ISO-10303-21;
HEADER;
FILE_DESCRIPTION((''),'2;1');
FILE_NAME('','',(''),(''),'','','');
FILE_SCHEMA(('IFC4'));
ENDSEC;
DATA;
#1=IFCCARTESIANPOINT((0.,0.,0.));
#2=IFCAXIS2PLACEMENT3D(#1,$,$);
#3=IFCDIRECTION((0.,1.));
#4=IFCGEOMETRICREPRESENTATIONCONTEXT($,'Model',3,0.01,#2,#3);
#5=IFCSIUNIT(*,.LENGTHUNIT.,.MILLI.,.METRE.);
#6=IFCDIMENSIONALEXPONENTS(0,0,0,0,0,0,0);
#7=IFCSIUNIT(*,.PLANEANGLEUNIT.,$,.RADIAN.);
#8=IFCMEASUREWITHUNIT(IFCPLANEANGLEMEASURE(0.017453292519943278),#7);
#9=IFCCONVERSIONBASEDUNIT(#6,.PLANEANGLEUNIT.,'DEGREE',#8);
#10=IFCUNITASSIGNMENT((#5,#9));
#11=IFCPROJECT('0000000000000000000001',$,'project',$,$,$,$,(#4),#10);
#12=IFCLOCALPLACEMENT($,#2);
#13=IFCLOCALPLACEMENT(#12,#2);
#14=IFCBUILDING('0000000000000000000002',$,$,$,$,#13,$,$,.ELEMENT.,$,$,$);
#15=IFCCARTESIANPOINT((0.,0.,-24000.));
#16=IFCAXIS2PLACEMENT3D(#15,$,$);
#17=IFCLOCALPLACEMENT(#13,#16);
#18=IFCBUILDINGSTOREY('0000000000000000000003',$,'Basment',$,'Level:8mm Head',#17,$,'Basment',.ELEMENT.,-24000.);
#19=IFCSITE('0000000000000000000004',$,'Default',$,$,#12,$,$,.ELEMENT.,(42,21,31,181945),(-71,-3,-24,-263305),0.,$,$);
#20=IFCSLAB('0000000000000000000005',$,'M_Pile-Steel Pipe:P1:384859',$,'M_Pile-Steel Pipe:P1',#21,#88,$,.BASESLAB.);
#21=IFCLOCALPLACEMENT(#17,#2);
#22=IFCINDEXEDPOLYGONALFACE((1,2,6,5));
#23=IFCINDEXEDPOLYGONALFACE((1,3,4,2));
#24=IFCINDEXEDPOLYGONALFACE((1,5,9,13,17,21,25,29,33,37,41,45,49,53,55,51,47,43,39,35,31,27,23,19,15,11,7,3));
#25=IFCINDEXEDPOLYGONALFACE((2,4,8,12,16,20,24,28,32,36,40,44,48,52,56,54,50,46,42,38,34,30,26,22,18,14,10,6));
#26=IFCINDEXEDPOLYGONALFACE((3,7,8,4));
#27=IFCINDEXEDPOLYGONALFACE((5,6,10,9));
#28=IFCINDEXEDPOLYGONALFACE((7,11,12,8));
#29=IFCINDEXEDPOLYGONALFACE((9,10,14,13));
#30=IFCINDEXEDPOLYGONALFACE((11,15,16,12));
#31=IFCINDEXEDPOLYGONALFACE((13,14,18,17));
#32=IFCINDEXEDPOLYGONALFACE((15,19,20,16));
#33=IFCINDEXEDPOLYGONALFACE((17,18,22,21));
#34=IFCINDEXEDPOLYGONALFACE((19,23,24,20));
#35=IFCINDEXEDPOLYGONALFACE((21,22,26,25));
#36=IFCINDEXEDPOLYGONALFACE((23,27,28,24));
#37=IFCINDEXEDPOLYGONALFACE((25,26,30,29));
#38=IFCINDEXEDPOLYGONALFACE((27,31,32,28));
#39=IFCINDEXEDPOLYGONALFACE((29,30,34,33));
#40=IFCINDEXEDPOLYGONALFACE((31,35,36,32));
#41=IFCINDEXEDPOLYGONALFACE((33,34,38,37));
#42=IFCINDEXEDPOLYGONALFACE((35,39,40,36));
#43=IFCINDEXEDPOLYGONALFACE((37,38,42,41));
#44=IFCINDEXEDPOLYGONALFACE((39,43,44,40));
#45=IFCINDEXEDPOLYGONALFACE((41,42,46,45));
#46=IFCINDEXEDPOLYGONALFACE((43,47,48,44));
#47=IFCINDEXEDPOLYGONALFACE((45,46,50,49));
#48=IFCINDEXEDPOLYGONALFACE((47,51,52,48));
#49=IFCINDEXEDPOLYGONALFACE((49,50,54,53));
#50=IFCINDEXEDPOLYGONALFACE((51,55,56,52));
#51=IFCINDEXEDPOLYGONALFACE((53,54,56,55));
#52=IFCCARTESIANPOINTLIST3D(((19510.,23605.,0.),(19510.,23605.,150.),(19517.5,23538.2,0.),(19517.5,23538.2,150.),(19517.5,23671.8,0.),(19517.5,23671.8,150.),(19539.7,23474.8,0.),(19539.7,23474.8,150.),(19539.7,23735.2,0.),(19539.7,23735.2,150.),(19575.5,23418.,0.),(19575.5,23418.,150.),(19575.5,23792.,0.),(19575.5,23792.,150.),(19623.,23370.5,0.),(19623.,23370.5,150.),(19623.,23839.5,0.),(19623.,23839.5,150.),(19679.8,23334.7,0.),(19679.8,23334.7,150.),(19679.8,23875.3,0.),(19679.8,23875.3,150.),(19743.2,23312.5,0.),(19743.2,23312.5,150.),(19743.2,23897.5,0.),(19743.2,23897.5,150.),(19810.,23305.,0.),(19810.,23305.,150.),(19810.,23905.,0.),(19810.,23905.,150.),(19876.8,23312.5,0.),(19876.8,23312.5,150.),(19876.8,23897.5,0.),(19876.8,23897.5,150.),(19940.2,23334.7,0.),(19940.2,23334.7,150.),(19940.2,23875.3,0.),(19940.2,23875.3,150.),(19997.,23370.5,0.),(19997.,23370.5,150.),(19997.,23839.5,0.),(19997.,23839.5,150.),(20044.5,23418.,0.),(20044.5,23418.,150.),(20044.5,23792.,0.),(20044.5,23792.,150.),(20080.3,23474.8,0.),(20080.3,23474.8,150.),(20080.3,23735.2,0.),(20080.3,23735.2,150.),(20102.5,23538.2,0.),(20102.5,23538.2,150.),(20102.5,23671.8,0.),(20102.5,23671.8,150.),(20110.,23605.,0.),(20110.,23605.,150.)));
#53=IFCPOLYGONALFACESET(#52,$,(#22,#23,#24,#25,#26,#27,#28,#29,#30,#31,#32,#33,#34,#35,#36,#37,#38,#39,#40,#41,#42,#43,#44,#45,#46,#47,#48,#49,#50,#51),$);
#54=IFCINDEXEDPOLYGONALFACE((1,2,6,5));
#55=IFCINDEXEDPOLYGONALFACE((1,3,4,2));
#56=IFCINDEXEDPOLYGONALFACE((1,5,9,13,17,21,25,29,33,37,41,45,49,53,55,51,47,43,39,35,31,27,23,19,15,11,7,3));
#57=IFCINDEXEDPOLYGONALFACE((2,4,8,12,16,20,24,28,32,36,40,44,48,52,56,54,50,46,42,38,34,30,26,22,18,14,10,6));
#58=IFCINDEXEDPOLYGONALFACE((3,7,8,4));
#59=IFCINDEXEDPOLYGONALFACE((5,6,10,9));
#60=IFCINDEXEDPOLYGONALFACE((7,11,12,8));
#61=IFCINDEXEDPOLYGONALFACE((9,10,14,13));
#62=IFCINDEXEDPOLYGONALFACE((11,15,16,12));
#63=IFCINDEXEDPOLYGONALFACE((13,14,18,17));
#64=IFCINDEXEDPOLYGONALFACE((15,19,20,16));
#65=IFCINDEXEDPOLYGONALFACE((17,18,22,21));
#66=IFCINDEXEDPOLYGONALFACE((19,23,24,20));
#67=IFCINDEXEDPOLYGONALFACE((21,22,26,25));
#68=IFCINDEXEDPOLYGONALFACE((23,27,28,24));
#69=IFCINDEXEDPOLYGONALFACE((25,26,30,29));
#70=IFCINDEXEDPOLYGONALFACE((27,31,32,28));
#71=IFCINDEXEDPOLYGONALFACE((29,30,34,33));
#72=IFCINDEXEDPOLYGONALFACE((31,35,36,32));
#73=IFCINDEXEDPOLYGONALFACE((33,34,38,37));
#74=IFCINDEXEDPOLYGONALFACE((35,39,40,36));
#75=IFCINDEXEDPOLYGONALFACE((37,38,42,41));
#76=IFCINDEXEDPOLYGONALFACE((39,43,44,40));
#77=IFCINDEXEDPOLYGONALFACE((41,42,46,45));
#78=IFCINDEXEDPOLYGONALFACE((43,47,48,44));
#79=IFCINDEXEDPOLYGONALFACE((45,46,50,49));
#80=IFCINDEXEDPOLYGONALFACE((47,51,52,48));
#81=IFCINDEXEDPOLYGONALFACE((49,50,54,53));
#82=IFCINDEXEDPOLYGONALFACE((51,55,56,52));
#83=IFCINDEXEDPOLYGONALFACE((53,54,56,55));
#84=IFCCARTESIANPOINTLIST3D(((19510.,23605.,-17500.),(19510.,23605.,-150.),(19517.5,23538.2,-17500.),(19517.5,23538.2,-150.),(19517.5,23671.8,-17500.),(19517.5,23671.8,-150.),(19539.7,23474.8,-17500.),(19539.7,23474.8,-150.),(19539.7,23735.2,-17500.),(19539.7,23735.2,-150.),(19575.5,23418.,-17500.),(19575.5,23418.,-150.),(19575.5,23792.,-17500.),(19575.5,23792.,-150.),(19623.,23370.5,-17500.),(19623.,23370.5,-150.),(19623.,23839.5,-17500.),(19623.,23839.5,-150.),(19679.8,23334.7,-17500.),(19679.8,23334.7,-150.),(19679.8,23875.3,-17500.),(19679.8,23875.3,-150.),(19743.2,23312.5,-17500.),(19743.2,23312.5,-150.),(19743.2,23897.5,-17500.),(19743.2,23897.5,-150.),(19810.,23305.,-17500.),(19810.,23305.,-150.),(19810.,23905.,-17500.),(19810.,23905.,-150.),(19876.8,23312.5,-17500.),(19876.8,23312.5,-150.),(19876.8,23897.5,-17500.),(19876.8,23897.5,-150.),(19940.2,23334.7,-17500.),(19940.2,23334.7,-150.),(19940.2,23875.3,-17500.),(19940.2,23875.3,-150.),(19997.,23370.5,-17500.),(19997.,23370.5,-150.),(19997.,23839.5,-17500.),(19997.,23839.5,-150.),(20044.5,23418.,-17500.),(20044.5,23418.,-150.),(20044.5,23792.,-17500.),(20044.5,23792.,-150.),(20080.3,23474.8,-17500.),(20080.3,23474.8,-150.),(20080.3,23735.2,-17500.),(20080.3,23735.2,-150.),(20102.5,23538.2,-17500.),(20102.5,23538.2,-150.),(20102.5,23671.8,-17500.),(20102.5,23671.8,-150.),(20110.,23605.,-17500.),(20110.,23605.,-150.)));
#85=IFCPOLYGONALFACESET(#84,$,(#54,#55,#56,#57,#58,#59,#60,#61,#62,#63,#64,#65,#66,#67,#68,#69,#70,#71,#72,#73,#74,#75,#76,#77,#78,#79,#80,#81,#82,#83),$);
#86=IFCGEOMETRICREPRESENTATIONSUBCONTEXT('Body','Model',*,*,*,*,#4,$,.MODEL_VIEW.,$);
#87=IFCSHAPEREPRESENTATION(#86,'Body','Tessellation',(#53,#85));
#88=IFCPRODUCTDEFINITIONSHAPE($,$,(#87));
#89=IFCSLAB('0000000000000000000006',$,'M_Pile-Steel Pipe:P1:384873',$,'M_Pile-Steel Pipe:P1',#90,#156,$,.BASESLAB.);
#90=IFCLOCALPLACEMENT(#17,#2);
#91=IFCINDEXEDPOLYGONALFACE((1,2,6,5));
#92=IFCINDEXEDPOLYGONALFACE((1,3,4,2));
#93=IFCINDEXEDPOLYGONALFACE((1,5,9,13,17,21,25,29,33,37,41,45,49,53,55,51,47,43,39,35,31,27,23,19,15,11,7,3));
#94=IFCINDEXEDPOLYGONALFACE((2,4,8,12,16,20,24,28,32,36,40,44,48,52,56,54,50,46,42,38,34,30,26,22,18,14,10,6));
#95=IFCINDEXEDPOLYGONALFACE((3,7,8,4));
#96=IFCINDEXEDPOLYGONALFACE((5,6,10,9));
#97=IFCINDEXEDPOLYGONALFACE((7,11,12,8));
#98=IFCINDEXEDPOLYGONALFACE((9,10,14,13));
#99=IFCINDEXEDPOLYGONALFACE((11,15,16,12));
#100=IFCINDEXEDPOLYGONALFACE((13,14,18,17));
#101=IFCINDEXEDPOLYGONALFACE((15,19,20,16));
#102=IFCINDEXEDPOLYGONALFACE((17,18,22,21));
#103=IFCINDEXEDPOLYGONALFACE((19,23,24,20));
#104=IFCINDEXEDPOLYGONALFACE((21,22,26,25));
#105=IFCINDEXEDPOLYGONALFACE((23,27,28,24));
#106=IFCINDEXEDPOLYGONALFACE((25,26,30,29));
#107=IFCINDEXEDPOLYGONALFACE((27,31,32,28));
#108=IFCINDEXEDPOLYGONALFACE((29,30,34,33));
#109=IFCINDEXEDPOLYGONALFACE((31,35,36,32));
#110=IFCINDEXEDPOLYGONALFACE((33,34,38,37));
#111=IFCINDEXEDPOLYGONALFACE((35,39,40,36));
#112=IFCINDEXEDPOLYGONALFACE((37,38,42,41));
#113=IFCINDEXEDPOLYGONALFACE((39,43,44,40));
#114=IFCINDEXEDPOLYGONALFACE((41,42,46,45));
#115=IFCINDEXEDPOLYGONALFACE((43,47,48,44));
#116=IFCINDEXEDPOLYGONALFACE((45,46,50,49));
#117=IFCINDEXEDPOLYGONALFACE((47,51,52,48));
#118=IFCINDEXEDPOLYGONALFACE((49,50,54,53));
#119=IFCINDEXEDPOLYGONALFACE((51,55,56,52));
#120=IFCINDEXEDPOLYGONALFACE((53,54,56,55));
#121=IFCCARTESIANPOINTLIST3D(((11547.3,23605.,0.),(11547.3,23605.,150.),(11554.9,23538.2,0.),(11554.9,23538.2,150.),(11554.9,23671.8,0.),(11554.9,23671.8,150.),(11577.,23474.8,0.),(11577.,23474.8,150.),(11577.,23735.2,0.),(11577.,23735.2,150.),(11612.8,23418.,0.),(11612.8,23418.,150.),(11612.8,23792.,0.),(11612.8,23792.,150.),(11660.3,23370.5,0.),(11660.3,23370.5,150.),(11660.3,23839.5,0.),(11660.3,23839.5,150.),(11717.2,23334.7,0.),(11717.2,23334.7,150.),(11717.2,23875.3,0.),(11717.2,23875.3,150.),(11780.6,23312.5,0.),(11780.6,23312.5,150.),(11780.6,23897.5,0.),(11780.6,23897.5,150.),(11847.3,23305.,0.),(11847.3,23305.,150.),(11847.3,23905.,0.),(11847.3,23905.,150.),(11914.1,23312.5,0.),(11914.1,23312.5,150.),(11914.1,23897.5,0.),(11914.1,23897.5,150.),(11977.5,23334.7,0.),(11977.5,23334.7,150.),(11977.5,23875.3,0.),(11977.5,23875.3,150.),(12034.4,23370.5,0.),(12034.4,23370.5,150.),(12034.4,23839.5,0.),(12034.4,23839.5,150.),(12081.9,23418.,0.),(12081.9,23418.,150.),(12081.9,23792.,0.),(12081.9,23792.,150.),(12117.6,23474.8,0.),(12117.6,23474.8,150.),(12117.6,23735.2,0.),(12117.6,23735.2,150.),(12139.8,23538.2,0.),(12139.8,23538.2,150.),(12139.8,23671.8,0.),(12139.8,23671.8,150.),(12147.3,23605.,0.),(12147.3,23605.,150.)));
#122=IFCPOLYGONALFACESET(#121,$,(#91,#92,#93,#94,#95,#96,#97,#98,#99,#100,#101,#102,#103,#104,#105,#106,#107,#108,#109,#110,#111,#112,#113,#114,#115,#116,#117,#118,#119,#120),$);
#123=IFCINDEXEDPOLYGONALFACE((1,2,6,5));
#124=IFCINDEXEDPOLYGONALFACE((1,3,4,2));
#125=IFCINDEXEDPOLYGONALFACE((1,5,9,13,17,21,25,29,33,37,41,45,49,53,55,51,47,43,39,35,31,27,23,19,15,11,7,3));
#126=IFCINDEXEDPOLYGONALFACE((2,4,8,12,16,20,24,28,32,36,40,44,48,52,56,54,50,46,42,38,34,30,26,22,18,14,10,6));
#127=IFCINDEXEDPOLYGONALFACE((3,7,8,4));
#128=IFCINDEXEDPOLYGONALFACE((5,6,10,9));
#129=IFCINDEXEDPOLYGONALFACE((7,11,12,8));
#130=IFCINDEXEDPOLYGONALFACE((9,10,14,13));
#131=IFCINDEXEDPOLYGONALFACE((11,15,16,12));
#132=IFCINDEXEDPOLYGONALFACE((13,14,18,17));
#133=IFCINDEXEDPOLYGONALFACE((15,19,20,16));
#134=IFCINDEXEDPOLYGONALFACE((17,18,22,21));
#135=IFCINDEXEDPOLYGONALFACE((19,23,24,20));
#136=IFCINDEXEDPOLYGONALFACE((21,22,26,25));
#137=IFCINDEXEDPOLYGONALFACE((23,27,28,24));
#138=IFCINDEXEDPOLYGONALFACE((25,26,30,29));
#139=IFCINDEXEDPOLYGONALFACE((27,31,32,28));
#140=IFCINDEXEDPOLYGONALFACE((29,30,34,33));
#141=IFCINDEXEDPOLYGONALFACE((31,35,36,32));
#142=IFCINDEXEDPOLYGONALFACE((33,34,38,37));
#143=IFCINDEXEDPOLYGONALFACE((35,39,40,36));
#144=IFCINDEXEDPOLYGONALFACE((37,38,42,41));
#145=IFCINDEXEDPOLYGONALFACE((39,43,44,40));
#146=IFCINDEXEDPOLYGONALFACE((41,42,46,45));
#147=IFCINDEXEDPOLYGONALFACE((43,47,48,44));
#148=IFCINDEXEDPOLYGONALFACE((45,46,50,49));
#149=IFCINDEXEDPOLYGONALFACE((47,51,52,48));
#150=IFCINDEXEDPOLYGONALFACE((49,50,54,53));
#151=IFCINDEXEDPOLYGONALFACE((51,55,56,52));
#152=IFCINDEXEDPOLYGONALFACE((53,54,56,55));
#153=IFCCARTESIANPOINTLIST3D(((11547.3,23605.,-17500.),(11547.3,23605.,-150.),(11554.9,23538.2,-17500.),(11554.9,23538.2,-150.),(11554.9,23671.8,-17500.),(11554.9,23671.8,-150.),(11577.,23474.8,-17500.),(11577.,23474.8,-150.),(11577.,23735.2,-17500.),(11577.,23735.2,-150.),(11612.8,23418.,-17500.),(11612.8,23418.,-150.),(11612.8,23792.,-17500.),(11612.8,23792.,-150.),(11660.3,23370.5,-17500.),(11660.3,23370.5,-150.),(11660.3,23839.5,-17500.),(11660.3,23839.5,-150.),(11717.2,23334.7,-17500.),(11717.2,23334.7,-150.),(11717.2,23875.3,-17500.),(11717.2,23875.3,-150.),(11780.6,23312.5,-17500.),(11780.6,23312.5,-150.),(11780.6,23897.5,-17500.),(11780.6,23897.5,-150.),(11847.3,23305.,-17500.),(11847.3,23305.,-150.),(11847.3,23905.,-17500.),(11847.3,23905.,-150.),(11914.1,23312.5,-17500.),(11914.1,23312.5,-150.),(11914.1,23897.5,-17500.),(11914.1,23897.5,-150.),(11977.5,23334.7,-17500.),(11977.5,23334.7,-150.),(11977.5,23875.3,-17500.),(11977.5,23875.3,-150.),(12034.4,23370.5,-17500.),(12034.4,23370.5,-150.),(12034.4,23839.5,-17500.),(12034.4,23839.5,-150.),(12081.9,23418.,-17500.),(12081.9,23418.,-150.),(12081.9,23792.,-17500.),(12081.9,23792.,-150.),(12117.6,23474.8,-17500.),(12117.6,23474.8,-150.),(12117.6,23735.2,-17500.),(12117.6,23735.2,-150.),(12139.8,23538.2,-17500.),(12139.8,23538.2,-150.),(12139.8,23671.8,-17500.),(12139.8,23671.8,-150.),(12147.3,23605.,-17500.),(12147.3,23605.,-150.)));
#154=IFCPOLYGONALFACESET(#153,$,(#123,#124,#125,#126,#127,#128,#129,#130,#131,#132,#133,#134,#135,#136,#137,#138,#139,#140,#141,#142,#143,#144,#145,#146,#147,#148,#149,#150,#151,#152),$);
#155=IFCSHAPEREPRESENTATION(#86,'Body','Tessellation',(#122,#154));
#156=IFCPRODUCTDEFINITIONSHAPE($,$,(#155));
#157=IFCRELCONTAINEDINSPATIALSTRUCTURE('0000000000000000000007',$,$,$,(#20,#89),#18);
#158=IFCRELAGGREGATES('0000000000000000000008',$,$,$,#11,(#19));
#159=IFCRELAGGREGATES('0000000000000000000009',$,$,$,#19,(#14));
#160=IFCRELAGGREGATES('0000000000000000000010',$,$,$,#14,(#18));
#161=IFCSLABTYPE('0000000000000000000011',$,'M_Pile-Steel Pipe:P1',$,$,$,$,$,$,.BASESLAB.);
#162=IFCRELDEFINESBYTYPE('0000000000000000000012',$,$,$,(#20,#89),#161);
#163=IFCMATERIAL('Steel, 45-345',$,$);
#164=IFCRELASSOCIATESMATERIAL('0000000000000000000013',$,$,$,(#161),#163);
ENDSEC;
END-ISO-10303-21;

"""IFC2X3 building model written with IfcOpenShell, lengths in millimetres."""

from ifc_helpers import new_model, entity, si_unit, converted_unit, direction, frame, frame_2d, origin, origin_2d_with_axis, place, context, subcontext, project, spatial, circle, extrude, material, type_object, element, save


model = new_model("IFC2X3")

# Units and contexts
model_context = context("Model", 3, precision=0.01, world=origin(), true_north=direction((0.0, 1.0)))
body_context = subcontext(model_context, "Body", "Model", "MODEL_VIEW")
ifc_project = project(units=[si_unit("LENGTHUNIT", "METRE", prefix="MILLI"), converted_unit("PLANEANGLEUNIT", "DEGREE", entity("IfcPlaneAngleMeasure", 0.017453292519943278), si_unit("PLANEANGLEUNIT", "RADIAN"), dimensions=[0, 0, 0, 0, 0, 0, 0])], contexts=[model_context])

# Site, building, storey
site_placement = place(None, origin())
site = spatial("IfcSite", under=ifc_project, at=site_placement, Name="Default", CompositionType="ELEMENT", RefLatitude=(42, 21, 31, 181945), RefLongitude=(-71, -3, -24, -263305), RefElevation=0.0)
building_placement = place(site_placement, origin())
building = spatial("IfcBuilding", under=site, at=building_placement, CompositionType="ELEMENT")
storey_placement = place(building_placement, frame((0.0, 0.0, -24000.0)))
storey = spatial("IfcBuildingStorey", under=building, at=storey_placement, Name="Basment", ObjectType="Level:8mm Head", LongName="Basment", CompositionType="ELEMENT", Elevation=-24000.0)

# Slabs
ifc_material_1 = material(Name="Steel, 45-345")
slab_type_1 = type_object("IfcSlabType", Name="M_Pile-Steel Pipe:P1", PredefinedType="BASESLAB", material=ifc_material_1)
slab_1_placement = place(storey_placement, origin())
element("IfcSlab", 1, at=slab_1_placement, inside=storey, type_object=slab_type_1, Name="M_Pile-Steel Pipe:P1:384859", ObjectType="M_Pile-Steel Pipe:P1", PredefinedType="BASESLAB", context=body_context, shape_type="SweptSolid", body=[
    extrude(circle(Radius=300.0, at=origin_2d_with_axis()), frame((19810.0, 23605.0, 0.0), z_axis=(0.0, 0.0, 1.0), x_axis=(0.0, 1.0, 0.0)), (0.0, 0.0, 1.0), 150.0),
    extrude(circle(Radius=300.0, at=origin_2d_with_axis()), frame((19810.0, 23605.0, -17500.0), z_axis=(0.0, 0.0, 1.0), x_axis=(0.0, 1.0, 0.0)), (0.0, 0.0, 1.0), 17350.0),
])
slab_2_placement = place(storey_placement, origin())
element("IfcSlab", 2, at=slab_2_placement, inside=storey, type_object=slab_type_1, Name="M_Pile-Steel Pipe:P1:384873", ObjectType="M_Pile-Steel Pipe:P1", PredefinedType="BASESLAB", context=body_context, shape_type="SweptSolid", body=[
    extrude(circle(Radius=300.0, at=frame_2d((0.0, 0.0), x_axis=(1.0, 0.0))), frame((11847.3, 23605.0, 0.0), z_axis=(0.0, 0.0, 1.0), x_axis=(0.0, 1.0, 0.0)), (0.0, 0.0, 1.0), 150.0),
    extrude(circle(Radius=300.0, at=frame_2d((0.0, 0.0), x_axis=(1.0, 0.0))), frame((11847.3, 23605.0, -17500.0), z_axis=(0.0, 0.0, 1.0), x_axis=(0.0, 1.0, 0.0)), (0.0, 0.0, 1.0), 17350.0),
])

save(model, "model.ifc")
